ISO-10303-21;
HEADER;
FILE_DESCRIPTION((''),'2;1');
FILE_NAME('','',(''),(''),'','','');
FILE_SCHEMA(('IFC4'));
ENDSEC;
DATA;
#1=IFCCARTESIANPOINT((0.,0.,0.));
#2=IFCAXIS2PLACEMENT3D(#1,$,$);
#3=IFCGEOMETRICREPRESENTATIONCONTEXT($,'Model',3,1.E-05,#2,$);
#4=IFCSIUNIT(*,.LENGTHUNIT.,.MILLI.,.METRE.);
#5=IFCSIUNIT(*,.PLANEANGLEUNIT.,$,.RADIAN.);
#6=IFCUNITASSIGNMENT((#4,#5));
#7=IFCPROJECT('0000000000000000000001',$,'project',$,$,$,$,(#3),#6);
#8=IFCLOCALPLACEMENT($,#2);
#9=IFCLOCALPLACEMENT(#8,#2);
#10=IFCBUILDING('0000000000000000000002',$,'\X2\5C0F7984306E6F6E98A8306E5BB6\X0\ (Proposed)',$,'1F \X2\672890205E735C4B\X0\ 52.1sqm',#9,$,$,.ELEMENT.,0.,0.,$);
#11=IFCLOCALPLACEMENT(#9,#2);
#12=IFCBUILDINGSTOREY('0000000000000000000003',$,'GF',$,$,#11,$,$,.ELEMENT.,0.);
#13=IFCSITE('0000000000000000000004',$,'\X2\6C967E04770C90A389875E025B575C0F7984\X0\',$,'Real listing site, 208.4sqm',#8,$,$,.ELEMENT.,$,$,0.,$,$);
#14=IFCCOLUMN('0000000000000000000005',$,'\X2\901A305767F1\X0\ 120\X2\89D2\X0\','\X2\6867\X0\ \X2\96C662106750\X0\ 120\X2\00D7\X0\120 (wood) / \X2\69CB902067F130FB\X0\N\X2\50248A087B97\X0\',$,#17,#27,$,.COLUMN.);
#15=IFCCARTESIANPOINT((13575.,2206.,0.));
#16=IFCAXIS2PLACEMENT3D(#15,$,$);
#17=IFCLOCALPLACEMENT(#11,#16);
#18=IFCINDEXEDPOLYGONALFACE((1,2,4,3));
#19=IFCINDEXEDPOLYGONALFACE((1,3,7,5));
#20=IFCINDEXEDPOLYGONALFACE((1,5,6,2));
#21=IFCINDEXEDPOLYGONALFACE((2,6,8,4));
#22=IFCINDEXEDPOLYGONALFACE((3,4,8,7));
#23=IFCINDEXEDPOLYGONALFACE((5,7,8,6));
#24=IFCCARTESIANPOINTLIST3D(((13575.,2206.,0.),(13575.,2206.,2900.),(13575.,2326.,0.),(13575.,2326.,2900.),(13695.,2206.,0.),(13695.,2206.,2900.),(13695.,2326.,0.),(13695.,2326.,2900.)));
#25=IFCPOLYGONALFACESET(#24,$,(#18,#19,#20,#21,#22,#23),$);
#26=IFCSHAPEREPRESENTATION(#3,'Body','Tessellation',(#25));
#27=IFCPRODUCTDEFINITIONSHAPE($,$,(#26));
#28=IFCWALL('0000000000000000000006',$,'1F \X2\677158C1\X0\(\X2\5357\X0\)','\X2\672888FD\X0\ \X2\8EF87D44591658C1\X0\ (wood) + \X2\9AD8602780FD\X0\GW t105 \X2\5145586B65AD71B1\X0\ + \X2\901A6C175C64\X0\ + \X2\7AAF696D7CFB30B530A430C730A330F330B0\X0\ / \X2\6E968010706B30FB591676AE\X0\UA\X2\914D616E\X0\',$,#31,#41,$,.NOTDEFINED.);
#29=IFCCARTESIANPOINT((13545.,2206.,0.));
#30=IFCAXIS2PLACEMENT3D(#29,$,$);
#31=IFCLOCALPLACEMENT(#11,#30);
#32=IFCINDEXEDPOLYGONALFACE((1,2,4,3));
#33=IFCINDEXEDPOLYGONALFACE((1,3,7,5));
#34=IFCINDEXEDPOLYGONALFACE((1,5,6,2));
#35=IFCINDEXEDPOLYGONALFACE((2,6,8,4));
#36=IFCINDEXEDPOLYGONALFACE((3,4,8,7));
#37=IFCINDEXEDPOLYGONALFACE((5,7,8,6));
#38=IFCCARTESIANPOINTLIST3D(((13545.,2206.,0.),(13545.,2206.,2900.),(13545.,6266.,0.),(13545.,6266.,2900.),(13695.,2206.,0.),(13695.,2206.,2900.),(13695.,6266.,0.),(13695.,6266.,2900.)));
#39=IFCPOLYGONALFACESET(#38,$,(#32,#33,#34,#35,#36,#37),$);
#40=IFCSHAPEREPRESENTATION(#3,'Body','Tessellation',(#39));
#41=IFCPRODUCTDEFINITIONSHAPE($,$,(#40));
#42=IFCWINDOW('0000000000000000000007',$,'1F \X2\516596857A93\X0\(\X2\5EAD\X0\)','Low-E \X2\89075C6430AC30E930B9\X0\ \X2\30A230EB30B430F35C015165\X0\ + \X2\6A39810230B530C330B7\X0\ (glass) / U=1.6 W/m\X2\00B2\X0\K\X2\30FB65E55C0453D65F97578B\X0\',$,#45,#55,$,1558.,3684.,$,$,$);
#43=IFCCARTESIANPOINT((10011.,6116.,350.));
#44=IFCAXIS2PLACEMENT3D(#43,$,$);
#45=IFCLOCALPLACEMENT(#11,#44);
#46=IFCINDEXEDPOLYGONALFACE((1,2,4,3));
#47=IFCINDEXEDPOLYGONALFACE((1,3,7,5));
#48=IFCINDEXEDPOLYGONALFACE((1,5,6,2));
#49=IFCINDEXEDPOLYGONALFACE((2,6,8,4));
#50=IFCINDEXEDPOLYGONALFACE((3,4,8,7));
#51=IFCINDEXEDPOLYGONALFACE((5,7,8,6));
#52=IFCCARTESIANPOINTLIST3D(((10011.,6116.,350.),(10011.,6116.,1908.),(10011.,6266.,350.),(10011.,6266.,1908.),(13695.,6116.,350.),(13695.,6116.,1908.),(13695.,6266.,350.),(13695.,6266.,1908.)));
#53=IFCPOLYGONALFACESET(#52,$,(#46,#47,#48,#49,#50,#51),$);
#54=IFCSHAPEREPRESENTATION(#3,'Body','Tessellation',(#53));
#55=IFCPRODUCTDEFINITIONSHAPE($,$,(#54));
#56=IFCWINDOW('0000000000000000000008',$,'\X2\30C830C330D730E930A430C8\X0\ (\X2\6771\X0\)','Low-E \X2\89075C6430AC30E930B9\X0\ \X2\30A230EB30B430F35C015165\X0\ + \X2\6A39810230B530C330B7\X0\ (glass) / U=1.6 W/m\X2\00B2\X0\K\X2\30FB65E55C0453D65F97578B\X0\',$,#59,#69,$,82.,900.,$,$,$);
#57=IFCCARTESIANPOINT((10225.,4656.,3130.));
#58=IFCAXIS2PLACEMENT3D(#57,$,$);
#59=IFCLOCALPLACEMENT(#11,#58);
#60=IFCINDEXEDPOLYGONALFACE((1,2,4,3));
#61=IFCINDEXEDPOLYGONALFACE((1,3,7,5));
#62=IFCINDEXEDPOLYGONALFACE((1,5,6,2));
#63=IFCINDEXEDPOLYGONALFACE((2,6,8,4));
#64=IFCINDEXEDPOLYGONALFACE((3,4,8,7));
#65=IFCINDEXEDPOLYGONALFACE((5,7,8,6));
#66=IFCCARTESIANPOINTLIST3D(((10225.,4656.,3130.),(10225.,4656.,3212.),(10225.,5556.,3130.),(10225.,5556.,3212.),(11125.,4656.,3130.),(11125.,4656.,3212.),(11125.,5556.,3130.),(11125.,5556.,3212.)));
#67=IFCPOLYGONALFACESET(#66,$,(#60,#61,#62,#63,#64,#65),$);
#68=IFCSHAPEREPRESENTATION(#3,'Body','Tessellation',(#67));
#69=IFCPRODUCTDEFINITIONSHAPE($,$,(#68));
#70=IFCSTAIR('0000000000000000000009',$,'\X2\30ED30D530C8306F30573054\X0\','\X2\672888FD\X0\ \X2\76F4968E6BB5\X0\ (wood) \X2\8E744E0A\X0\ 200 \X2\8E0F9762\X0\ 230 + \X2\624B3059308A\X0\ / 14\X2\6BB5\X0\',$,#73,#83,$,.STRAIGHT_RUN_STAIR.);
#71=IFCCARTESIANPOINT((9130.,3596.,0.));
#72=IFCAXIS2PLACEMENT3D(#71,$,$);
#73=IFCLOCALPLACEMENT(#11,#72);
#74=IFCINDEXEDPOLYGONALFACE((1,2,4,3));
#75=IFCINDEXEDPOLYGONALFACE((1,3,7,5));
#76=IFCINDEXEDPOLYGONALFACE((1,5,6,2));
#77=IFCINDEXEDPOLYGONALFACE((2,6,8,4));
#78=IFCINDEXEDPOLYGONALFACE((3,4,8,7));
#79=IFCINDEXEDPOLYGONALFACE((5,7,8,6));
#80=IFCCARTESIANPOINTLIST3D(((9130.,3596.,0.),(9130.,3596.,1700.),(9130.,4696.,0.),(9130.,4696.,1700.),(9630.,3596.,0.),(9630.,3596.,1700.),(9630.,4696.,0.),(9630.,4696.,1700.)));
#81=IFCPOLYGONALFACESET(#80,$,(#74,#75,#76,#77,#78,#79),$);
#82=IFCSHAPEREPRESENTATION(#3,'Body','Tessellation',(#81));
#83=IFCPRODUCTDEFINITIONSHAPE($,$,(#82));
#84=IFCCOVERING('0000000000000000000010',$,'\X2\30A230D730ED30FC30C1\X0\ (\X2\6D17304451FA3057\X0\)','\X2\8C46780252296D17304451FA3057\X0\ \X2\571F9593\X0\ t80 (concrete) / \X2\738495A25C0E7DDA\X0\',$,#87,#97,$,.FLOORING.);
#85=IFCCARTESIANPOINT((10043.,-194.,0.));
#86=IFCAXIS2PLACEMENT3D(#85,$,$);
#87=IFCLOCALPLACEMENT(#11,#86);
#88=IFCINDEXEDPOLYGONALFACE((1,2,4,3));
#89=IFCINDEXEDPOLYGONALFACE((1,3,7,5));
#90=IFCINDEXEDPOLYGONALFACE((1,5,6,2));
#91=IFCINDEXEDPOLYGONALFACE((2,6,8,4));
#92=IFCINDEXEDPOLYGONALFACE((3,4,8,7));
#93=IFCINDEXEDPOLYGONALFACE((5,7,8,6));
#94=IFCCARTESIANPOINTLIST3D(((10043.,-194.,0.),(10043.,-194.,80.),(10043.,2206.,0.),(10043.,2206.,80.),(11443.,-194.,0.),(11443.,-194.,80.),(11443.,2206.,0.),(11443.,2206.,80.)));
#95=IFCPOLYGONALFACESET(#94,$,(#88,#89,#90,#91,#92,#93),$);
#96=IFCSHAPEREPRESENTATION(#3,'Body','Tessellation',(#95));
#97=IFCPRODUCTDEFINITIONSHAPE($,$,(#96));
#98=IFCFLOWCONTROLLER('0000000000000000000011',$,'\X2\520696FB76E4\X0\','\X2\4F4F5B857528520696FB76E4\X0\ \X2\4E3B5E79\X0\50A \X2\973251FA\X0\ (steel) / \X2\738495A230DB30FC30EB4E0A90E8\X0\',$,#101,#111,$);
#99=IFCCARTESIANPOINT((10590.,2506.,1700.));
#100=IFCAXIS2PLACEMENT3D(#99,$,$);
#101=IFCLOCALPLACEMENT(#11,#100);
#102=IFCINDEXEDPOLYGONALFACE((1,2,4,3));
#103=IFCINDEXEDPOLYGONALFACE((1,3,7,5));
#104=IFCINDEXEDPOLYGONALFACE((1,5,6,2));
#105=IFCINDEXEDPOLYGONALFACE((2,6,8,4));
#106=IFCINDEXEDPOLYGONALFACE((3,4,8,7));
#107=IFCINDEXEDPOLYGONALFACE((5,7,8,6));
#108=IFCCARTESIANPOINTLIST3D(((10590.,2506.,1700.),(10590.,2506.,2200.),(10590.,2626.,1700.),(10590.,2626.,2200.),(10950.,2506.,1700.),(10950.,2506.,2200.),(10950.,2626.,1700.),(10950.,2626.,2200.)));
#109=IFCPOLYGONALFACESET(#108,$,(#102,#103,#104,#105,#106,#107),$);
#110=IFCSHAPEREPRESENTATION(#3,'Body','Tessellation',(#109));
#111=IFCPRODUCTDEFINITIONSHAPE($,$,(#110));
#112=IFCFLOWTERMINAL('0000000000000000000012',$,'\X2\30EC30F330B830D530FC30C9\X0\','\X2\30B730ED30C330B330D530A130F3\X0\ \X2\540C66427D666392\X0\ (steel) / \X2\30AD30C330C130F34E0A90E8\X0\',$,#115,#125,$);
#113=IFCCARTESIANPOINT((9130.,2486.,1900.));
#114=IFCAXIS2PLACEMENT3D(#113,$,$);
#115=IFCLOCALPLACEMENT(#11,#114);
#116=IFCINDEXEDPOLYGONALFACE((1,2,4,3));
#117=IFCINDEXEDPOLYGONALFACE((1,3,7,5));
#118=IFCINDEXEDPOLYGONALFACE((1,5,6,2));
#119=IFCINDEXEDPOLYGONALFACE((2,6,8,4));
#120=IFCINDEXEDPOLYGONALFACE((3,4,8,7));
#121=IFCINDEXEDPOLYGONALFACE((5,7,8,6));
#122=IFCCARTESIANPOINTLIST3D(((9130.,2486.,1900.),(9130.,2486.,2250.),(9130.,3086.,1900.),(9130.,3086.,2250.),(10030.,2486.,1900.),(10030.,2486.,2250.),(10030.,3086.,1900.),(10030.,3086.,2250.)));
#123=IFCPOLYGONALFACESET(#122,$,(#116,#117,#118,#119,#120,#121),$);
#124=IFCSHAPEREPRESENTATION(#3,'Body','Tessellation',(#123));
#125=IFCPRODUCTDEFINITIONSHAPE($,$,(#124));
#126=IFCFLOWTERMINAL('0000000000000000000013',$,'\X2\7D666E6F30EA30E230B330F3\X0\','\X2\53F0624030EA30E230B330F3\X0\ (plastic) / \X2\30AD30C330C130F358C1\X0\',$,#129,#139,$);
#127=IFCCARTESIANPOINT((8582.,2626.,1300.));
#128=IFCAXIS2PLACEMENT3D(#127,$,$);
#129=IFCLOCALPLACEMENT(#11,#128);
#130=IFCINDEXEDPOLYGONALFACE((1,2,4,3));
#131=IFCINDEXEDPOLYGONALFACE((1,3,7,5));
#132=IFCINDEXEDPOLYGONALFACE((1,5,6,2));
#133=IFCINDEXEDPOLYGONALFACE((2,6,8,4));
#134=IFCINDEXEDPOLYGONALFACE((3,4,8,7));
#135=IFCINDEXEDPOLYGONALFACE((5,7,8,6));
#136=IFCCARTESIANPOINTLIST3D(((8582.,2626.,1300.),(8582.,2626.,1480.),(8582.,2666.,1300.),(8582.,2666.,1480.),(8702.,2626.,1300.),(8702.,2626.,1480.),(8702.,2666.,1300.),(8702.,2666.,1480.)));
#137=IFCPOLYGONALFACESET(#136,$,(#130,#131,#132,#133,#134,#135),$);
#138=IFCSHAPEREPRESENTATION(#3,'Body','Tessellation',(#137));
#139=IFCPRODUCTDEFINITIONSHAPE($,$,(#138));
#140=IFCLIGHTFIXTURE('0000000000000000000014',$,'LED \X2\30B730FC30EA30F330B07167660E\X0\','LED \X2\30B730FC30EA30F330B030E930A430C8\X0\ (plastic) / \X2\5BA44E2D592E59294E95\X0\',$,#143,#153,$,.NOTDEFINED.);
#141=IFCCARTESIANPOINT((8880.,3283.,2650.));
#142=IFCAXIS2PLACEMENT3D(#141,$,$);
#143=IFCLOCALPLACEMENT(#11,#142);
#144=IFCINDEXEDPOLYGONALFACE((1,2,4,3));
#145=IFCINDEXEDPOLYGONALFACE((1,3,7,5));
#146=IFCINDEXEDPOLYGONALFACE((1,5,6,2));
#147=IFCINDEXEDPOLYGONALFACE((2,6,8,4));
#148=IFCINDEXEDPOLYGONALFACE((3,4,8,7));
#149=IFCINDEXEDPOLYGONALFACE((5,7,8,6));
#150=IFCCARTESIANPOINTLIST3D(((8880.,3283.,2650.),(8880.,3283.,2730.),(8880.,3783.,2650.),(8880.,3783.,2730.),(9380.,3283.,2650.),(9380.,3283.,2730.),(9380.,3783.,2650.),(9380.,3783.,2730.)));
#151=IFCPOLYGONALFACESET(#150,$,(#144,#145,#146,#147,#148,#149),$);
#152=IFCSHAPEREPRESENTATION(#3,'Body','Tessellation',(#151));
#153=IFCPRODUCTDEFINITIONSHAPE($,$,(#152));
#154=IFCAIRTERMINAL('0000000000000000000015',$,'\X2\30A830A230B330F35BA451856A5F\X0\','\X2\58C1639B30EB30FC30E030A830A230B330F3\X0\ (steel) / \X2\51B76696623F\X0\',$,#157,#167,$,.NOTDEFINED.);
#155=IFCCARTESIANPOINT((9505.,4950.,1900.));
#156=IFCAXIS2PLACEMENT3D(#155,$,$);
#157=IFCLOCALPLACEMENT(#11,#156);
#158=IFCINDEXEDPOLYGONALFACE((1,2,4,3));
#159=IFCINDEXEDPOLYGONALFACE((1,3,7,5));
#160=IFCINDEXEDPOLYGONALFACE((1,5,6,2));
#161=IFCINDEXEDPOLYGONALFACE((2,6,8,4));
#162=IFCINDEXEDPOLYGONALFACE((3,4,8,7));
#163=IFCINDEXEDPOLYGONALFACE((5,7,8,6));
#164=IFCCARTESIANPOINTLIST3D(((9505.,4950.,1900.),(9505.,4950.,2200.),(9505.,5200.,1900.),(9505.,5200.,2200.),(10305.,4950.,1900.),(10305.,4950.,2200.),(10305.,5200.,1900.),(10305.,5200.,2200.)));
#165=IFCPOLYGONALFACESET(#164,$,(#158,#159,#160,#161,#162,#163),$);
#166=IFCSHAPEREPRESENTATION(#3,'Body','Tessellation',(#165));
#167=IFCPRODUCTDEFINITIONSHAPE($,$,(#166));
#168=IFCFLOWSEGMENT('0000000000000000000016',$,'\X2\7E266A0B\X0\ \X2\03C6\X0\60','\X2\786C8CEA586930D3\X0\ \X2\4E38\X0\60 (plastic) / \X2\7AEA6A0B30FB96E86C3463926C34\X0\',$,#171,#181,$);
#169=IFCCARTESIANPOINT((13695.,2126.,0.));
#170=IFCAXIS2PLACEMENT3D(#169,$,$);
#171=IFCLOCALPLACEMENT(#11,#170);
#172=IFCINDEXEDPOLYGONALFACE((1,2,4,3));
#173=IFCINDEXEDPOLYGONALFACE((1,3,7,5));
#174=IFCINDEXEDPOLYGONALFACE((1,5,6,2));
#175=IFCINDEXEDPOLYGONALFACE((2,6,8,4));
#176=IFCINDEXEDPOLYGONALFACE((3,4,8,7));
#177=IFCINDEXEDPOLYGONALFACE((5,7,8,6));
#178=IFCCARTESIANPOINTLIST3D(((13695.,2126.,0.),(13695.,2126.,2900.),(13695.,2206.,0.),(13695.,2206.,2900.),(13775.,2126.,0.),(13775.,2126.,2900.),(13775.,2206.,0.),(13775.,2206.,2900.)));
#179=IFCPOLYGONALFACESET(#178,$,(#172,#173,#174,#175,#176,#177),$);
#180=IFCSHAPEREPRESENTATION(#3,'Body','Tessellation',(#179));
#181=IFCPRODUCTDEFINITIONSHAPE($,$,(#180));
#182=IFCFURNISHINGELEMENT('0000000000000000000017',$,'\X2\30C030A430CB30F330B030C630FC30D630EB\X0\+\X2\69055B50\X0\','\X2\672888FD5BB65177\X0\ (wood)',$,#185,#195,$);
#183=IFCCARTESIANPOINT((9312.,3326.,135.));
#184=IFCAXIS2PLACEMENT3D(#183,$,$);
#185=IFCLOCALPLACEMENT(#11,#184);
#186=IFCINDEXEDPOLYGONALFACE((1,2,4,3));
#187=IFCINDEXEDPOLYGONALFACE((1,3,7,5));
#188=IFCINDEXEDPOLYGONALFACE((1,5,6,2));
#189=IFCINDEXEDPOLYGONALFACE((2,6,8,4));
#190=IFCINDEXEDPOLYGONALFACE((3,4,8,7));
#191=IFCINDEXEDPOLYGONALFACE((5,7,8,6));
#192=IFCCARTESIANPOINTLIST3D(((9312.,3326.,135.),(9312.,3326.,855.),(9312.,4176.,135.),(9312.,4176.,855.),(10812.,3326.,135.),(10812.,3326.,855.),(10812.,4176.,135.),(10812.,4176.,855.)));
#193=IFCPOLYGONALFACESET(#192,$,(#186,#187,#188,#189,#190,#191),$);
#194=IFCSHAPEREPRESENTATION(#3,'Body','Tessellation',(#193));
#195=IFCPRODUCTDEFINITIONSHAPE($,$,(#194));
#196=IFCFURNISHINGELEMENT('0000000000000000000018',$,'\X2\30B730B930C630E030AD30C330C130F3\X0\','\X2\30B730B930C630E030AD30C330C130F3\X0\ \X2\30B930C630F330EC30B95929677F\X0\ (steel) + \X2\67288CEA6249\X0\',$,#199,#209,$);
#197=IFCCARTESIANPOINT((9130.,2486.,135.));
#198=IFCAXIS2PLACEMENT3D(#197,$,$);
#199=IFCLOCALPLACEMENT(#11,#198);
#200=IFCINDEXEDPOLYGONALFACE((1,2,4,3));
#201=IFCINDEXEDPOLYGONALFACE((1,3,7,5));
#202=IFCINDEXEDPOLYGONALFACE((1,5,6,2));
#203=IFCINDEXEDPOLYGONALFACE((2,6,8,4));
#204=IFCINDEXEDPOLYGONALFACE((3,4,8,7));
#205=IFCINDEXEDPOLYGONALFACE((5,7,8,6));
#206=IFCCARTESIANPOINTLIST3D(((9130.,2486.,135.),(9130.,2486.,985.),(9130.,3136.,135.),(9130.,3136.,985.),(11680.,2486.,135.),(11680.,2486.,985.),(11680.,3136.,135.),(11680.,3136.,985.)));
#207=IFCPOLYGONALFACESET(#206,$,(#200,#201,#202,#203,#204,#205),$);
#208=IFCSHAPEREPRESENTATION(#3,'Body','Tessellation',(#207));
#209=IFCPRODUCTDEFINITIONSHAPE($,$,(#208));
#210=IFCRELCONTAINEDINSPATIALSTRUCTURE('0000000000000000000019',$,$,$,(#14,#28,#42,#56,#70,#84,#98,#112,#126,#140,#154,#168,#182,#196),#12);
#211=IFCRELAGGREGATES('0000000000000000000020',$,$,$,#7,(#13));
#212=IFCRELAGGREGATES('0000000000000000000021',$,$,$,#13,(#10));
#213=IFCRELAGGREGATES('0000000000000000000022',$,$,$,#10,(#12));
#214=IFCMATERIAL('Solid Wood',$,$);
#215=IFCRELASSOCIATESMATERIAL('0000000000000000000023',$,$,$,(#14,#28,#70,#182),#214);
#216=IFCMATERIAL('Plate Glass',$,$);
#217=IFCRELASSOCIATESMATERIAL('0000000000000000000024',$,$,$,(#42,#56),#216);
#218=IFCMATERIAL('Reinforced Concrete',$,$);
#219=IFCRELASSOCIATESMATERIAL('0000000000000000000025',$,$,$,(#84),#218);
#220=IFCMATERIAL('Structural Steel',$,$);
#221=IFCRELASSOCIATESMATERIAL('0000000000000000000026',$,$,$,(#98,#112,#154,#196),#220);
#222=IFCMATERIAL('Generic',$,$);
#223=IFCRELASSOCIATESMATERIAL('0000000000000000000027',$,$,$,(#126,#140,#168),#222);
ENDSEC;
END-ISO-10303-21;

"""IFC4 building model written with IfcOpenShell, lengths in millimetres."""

from ifc_helpers import new_model, si_unit, frame, frame_2d, origin, place, context, project, spatial, rectangle, extrude, material, element, fill, save


model = new_model("IFC4")

# Units and contexts
model_context = context("Model", 3, precision=1e-05, world=origin())
ifc_project = project(units=[si_unit("LENGTHUNIT", "METRE", prefix="MILLI"), si_unit("PLANEANGLEUNIT", "RADIAN")], contexts=[model_context])

# Site, building, storey
site_placement = place(None, origin())
site = spatial("IfcSite", under=ifc_project, at=site_placement, Name="沖縄県那覇市字小禄", ObjectType="Real listing site, 208.4sqm", CompositionType="ELEMENT", RefElevation=0.0)
building_placement = place(site_placement, origin())
building = spatial("IfcBuilding", under=site, at=building_placement, Name="小禄の潮風の家 (Proposed)", ObjectType="1F 木造平屋 52.1sqm", CompositionType="ELEMENT", ElevationOfRefHeight=0.0, ElevationOfTerrain=0.0)
storey_placement = place(building_placement, origin())
storey = spatial("IfcBuildingStorey", under=building, at=storey_placement, Name="GF", CompositionType="ELEMENT", Elevation=0.0)

# Column
ifc_material_1 = material(Name="Solid Wood")
column_1_placement = place(storey_placement, frame((13575.0, 2206.0, 0.0)))
element("IfcColumn", 1, at=column_1_placement, inside=storey, material=ifc_material_1, Name="通し柱 120角", Description="桧 集成材 120×120 (wood) / 構造柱・N値計算", PredefinedType="COLUMN", context=model_context, shape_type="SweptSolid", body=[
    extrude(rectangle(XDim=120.0, YDim=120.0, at=frame_2d((60.0, 60.0))), frame((13575.0, 2206.0, 0.0)), (0.0, 0.0, 1.0), 2900.0),
])

# Wall, opening, window
wall_1_placement = place(storey_placement, frame((13545.0, 2206.0, 0.0)))
wall_1 = element("IfcWall", 2, at=wall_1_placement, inside=storey, material=ifc_material_1, Name="1F 東壁(南)", Description="木製 軸組外壁 (wood) + 高性能GW t105 充填断熱 + 通気層 + 窯業系サイディング / 準耐火・外皮UA配慮", PredefinedType="NOTDEFINED", context=model_context, shape_type="SweptSolid", body=[
    extrude(rectangle(XDim=150.0, YDim=4060.0, at=frame_2d((75.0, 2030.0))), frame((13545.0, 2206.0, 0.0)), (0.0, 0.0, 1.0), 2900.0),
])
opening_placement = place(storey_placement, frame((10011.0, 6116.0, 350.0)))
opening = element("IfcOpeningElement", 3, at=opening_placement, cuts=wall_1, PredefinedType="NOTDEFINED", context=model_context, shape_type="SweptSolid", body=[
    extrude(rectangle(XDim=3684.0, YDim=150.0, at=frame_2d((1842.0, 75.0))), frame((10011.0, 6116.0, 350.0)), (0.0, 0.0, 1.0), 1558.0),
])
ifc_material_2 = material(Name="Plate Glass")
window_1_placement = place(storey_placement, frame((10011.0, 6116.0, 350.0)))
window_1 = element("IfcWindow", 4, at=window_1_placement, inside=storey, material=ifc_material_2, Name="1F 入隅窓(庭)", Description="Low-E 複層ガラス アルゴン封入 + 樹脂サッシ (glass) / U=1.6 W/m²K・日射取得型", OverallHeight=1558.0, OverallWidth=3684.0, context=model_context, shape_type="SweptSolid", body=[
    extrude(rectangle(XDim=3684.0, YDim=150.0, at=frame_2d((1842.0, 75.0))), frame((10011.0, 6116.0, 350.0)), (0.0, 0.0, 1.0), 1558.0),
])
fill(opening, window_1)

# Window
window_2_placement = place(storey_placement, frame((10225.0, 4656.0, 3130.0)))
element("IfcWindow", 5, at=window_2_placement, inside=storey, material=ifc_material_2, Name="トップライト (東)", Description="Low-E 複層ガラス アルゴン封入 + 樹脂サッシ (glass) / U=1.6 W/m²K・日射取得型", OverallHeight=82.0, OverallWidth=900.0, context=model_context, shape_type="SweptSolid", body=[
    extrude(rectangle(XDim=900.0, YDim=900.0, at=frame_2d((450.0, 450.0))), frame((10225.0, 4656.0, 3130.0)), (0.0, 0.0, 1.0), 82.0),
])

# Stair
stair_placement = place(storey_placement, frame((9130.0, 3596.0, 0.0)))
element("IfcStair", 6, at=stair_placement, inside=storey, material=ifc_material_1, Name="ロフトはしご", Description="木製 直階段 (wood) 蹴上 200 踏面 230 + 手すり / 14段", PredefinedType="STRAIGHT_RUN_STAIR", context=model_context, shape_type="SweptSolid", body=[
    extrude(rectangle(XDim=500.0, YDim=1100.0, at=frame_2d((250.0, 550.0))), frame((9130.0, 3596.0, 0.0)), (0.0, 0.0, 1.0), 1700.0),
])

# Covering
ifc_material_3 = material(Name="Reinforced Concrete")
covering_placement = place(storey_placement, frame((10043.0, -194.0, 0.0)))
element("IfcCovering", 7, at=covering_placement, inside=storey, material=ifc_material_3, Name="アプローチ (洗い出し)", Description="豆砂利洗い出し 土間 t80 (concrete) / 玄関導線", PredefinedType="FLOORING", context=model_context, shape_type="SweptSolid", body=[
    extrude(rectangle(XDim=1400.0, YDim=2400.0, at=frame_2d((700.0, 1200.0))), frame((10043.0, -194.0, 0.0)), (0.0, 0.0, 1.0), 80.0),
])

# Flow controller
ifc_material_4 = material(Name="Structural Steel")
flow_controller_placement = place(storey_placement, frame((10590.0, 2506.0, 1700.0)))
element("IfcFlowController", 8, at=flow_controller_placement, inside=storey, material=ifc_material_4, Name="分電盤", Description="住宅用分電盤 主幹50A 露出 (steel) / 玄関ホール上部", context=model_context, shape_type="SweptSolid", body=[
    extrude(rectangle(XDim=360.0, YDim=120.0, at=frame_2d((180.0, 60.0))), frame((10590.0, 2506.0, 1700.0)), (0.0, 0.0, 1.0), 500.0),
])

# Flow terminals
flow_terminal_1_placement = place(storey_placement, frame((9130.0, 2486.0, 1900.0)))
element("IfcFlowTerminal", 9, at=flow_terminal_1_placement, inside=storey, material=ifc_material_4, Name="レンジフード", Description="シロッコファン 同時給排 (steel) / キッチン上部", context=model_context, shape_type="SweptSolid", body=[
    extrude(rectangle(XDim=900.0, YDim=600.0, at=frame_2d((450.0, 300.0))), frame((9130.0, 2486.0, 1900.0)), (0.0, 0.0, 1.0), 350.0),
])
ifc_material_5 = material(Name="Generic")
flow_terminal_2_placement = place(storey_placement, frame((8582.0, 2626.0, 1300.0)))
element("IfcFlowTerminal", 10, at=flow_terminal_2_placement, inside=storey, material=ifc_material_5, Name="給湯リモコン", Description="台所リモコン (plastic) / キッチン壁", context=model_context, shape_type="SweptSolid", body=[
    extrude(rectangle(XDim=120.0, YDim=40.0, at=frame_2d((60.0, 20.0))), frame((8582.0, 2626.0, 1300.0)), (0.0, 0.0, 1.0), 180.0),
])

# Light fixture
light_fixture_placement = place(storey_placement, frame((8880.0, 3283.0, 2650.0)))
element("IfcLightFixture", 11, at=light_fixture_placement, inside=storey, material=ifc_material_5, Name="LED シーリング照明", Description="LED シーリングライト (plastic) / 室中央天井", PredefinedType="NOTDEFINED", context=model_context, shape_type="SweptSolid", body=[
    extrude(rectangle(XDim=500.0, YDim=500.0, at=frame_2d((250.0, 250.0))), frame((8880.0, 3283.0, 2650.0)), (0.0, 0.0, 1.0), 80.0),
])

# Air terminal
air_terminal_placement = place(storey_placement, frame((9505.0, 4950.0, 1900.0)))
element("IfcAirTerminal", 12, at=air_terminal_placement, inside=storey, material=ifc_material_4, Name="エアコン室内機", Description="壁掛ルームエアコン (steel) / 冷暖房", PredefinedType="NOTDEFINED", context=model_context, shape_type="SweptSolid", body=[
    extrude(rectangle(XDim=800.0, YDim=250.0, at=frame_2d((400.0, 125.0))), frame((9505.0, 4950.0, 1900.0)), (0.0, 0.0, 1.0), 300.0),
])

# Flow segment
flow_segment_placement = place(storey_placement, frame((13695.0, 2126.0, 0.0)))
element("IfcFlowSegment", 13, at=flow_segment_placement, inside=storey, material=ifc_material_5, Name="縦樋 φ60", Description="硬質塩ビ 丸60 (plastic) / 竪樋・雨水排水", context=model_context, shape_type="SweptSolid", body=[
    extrude(rectangle(XDim=80.0, YDim=80.0, at=frame_2d((40.0, 40.0))), frame((13695.0, 2126.0, 0.0)), (0.0, 0.0, 1.0), 2900.0),
])

# Furnishing elements
furnishing_1_placement = place(storey_placement, frame((9312.0, 3326.0, 135.0)))
element("IfcFurnishingElement", 14, at=furnishing_1_placement, inside=storey, material=ifc_material_1, Name="ダイニングテーブル+椅子", Description="木製家具 (wood)", context=model_context, shape_type="SweptSolid", body=[
    extrude(rectangle(XDim=1500.0, YDim=850.0, at=frame_2d((750.0, 425.0))), frame((9312.0, 3326.0, 135.0)), (0.0, 0.0, 1.0), 720.0),
])
furnishing_2_placement = place(storey_placement, frame((9130.0, 2486.0, 135.0)))
element("IfcFurnishingElement", 15, at=furnishing_2_placement, inside=storey, material=ifc_material_4, Name="システムキッチン", Description="システムキッチン ステンレス天板 (steel) + 木質扉", context=model_context, shape_type="SweptSolid", body=[
    extrude(rectangle(XDim=2550.0, YDim=650.0, at=frame_2d((1275.0, 325.0))), frame((9130.0, 2486.0, 135.0)), (0.0, 0.0, 1.0), 850.0),
])

save(model, "model.ifc")
